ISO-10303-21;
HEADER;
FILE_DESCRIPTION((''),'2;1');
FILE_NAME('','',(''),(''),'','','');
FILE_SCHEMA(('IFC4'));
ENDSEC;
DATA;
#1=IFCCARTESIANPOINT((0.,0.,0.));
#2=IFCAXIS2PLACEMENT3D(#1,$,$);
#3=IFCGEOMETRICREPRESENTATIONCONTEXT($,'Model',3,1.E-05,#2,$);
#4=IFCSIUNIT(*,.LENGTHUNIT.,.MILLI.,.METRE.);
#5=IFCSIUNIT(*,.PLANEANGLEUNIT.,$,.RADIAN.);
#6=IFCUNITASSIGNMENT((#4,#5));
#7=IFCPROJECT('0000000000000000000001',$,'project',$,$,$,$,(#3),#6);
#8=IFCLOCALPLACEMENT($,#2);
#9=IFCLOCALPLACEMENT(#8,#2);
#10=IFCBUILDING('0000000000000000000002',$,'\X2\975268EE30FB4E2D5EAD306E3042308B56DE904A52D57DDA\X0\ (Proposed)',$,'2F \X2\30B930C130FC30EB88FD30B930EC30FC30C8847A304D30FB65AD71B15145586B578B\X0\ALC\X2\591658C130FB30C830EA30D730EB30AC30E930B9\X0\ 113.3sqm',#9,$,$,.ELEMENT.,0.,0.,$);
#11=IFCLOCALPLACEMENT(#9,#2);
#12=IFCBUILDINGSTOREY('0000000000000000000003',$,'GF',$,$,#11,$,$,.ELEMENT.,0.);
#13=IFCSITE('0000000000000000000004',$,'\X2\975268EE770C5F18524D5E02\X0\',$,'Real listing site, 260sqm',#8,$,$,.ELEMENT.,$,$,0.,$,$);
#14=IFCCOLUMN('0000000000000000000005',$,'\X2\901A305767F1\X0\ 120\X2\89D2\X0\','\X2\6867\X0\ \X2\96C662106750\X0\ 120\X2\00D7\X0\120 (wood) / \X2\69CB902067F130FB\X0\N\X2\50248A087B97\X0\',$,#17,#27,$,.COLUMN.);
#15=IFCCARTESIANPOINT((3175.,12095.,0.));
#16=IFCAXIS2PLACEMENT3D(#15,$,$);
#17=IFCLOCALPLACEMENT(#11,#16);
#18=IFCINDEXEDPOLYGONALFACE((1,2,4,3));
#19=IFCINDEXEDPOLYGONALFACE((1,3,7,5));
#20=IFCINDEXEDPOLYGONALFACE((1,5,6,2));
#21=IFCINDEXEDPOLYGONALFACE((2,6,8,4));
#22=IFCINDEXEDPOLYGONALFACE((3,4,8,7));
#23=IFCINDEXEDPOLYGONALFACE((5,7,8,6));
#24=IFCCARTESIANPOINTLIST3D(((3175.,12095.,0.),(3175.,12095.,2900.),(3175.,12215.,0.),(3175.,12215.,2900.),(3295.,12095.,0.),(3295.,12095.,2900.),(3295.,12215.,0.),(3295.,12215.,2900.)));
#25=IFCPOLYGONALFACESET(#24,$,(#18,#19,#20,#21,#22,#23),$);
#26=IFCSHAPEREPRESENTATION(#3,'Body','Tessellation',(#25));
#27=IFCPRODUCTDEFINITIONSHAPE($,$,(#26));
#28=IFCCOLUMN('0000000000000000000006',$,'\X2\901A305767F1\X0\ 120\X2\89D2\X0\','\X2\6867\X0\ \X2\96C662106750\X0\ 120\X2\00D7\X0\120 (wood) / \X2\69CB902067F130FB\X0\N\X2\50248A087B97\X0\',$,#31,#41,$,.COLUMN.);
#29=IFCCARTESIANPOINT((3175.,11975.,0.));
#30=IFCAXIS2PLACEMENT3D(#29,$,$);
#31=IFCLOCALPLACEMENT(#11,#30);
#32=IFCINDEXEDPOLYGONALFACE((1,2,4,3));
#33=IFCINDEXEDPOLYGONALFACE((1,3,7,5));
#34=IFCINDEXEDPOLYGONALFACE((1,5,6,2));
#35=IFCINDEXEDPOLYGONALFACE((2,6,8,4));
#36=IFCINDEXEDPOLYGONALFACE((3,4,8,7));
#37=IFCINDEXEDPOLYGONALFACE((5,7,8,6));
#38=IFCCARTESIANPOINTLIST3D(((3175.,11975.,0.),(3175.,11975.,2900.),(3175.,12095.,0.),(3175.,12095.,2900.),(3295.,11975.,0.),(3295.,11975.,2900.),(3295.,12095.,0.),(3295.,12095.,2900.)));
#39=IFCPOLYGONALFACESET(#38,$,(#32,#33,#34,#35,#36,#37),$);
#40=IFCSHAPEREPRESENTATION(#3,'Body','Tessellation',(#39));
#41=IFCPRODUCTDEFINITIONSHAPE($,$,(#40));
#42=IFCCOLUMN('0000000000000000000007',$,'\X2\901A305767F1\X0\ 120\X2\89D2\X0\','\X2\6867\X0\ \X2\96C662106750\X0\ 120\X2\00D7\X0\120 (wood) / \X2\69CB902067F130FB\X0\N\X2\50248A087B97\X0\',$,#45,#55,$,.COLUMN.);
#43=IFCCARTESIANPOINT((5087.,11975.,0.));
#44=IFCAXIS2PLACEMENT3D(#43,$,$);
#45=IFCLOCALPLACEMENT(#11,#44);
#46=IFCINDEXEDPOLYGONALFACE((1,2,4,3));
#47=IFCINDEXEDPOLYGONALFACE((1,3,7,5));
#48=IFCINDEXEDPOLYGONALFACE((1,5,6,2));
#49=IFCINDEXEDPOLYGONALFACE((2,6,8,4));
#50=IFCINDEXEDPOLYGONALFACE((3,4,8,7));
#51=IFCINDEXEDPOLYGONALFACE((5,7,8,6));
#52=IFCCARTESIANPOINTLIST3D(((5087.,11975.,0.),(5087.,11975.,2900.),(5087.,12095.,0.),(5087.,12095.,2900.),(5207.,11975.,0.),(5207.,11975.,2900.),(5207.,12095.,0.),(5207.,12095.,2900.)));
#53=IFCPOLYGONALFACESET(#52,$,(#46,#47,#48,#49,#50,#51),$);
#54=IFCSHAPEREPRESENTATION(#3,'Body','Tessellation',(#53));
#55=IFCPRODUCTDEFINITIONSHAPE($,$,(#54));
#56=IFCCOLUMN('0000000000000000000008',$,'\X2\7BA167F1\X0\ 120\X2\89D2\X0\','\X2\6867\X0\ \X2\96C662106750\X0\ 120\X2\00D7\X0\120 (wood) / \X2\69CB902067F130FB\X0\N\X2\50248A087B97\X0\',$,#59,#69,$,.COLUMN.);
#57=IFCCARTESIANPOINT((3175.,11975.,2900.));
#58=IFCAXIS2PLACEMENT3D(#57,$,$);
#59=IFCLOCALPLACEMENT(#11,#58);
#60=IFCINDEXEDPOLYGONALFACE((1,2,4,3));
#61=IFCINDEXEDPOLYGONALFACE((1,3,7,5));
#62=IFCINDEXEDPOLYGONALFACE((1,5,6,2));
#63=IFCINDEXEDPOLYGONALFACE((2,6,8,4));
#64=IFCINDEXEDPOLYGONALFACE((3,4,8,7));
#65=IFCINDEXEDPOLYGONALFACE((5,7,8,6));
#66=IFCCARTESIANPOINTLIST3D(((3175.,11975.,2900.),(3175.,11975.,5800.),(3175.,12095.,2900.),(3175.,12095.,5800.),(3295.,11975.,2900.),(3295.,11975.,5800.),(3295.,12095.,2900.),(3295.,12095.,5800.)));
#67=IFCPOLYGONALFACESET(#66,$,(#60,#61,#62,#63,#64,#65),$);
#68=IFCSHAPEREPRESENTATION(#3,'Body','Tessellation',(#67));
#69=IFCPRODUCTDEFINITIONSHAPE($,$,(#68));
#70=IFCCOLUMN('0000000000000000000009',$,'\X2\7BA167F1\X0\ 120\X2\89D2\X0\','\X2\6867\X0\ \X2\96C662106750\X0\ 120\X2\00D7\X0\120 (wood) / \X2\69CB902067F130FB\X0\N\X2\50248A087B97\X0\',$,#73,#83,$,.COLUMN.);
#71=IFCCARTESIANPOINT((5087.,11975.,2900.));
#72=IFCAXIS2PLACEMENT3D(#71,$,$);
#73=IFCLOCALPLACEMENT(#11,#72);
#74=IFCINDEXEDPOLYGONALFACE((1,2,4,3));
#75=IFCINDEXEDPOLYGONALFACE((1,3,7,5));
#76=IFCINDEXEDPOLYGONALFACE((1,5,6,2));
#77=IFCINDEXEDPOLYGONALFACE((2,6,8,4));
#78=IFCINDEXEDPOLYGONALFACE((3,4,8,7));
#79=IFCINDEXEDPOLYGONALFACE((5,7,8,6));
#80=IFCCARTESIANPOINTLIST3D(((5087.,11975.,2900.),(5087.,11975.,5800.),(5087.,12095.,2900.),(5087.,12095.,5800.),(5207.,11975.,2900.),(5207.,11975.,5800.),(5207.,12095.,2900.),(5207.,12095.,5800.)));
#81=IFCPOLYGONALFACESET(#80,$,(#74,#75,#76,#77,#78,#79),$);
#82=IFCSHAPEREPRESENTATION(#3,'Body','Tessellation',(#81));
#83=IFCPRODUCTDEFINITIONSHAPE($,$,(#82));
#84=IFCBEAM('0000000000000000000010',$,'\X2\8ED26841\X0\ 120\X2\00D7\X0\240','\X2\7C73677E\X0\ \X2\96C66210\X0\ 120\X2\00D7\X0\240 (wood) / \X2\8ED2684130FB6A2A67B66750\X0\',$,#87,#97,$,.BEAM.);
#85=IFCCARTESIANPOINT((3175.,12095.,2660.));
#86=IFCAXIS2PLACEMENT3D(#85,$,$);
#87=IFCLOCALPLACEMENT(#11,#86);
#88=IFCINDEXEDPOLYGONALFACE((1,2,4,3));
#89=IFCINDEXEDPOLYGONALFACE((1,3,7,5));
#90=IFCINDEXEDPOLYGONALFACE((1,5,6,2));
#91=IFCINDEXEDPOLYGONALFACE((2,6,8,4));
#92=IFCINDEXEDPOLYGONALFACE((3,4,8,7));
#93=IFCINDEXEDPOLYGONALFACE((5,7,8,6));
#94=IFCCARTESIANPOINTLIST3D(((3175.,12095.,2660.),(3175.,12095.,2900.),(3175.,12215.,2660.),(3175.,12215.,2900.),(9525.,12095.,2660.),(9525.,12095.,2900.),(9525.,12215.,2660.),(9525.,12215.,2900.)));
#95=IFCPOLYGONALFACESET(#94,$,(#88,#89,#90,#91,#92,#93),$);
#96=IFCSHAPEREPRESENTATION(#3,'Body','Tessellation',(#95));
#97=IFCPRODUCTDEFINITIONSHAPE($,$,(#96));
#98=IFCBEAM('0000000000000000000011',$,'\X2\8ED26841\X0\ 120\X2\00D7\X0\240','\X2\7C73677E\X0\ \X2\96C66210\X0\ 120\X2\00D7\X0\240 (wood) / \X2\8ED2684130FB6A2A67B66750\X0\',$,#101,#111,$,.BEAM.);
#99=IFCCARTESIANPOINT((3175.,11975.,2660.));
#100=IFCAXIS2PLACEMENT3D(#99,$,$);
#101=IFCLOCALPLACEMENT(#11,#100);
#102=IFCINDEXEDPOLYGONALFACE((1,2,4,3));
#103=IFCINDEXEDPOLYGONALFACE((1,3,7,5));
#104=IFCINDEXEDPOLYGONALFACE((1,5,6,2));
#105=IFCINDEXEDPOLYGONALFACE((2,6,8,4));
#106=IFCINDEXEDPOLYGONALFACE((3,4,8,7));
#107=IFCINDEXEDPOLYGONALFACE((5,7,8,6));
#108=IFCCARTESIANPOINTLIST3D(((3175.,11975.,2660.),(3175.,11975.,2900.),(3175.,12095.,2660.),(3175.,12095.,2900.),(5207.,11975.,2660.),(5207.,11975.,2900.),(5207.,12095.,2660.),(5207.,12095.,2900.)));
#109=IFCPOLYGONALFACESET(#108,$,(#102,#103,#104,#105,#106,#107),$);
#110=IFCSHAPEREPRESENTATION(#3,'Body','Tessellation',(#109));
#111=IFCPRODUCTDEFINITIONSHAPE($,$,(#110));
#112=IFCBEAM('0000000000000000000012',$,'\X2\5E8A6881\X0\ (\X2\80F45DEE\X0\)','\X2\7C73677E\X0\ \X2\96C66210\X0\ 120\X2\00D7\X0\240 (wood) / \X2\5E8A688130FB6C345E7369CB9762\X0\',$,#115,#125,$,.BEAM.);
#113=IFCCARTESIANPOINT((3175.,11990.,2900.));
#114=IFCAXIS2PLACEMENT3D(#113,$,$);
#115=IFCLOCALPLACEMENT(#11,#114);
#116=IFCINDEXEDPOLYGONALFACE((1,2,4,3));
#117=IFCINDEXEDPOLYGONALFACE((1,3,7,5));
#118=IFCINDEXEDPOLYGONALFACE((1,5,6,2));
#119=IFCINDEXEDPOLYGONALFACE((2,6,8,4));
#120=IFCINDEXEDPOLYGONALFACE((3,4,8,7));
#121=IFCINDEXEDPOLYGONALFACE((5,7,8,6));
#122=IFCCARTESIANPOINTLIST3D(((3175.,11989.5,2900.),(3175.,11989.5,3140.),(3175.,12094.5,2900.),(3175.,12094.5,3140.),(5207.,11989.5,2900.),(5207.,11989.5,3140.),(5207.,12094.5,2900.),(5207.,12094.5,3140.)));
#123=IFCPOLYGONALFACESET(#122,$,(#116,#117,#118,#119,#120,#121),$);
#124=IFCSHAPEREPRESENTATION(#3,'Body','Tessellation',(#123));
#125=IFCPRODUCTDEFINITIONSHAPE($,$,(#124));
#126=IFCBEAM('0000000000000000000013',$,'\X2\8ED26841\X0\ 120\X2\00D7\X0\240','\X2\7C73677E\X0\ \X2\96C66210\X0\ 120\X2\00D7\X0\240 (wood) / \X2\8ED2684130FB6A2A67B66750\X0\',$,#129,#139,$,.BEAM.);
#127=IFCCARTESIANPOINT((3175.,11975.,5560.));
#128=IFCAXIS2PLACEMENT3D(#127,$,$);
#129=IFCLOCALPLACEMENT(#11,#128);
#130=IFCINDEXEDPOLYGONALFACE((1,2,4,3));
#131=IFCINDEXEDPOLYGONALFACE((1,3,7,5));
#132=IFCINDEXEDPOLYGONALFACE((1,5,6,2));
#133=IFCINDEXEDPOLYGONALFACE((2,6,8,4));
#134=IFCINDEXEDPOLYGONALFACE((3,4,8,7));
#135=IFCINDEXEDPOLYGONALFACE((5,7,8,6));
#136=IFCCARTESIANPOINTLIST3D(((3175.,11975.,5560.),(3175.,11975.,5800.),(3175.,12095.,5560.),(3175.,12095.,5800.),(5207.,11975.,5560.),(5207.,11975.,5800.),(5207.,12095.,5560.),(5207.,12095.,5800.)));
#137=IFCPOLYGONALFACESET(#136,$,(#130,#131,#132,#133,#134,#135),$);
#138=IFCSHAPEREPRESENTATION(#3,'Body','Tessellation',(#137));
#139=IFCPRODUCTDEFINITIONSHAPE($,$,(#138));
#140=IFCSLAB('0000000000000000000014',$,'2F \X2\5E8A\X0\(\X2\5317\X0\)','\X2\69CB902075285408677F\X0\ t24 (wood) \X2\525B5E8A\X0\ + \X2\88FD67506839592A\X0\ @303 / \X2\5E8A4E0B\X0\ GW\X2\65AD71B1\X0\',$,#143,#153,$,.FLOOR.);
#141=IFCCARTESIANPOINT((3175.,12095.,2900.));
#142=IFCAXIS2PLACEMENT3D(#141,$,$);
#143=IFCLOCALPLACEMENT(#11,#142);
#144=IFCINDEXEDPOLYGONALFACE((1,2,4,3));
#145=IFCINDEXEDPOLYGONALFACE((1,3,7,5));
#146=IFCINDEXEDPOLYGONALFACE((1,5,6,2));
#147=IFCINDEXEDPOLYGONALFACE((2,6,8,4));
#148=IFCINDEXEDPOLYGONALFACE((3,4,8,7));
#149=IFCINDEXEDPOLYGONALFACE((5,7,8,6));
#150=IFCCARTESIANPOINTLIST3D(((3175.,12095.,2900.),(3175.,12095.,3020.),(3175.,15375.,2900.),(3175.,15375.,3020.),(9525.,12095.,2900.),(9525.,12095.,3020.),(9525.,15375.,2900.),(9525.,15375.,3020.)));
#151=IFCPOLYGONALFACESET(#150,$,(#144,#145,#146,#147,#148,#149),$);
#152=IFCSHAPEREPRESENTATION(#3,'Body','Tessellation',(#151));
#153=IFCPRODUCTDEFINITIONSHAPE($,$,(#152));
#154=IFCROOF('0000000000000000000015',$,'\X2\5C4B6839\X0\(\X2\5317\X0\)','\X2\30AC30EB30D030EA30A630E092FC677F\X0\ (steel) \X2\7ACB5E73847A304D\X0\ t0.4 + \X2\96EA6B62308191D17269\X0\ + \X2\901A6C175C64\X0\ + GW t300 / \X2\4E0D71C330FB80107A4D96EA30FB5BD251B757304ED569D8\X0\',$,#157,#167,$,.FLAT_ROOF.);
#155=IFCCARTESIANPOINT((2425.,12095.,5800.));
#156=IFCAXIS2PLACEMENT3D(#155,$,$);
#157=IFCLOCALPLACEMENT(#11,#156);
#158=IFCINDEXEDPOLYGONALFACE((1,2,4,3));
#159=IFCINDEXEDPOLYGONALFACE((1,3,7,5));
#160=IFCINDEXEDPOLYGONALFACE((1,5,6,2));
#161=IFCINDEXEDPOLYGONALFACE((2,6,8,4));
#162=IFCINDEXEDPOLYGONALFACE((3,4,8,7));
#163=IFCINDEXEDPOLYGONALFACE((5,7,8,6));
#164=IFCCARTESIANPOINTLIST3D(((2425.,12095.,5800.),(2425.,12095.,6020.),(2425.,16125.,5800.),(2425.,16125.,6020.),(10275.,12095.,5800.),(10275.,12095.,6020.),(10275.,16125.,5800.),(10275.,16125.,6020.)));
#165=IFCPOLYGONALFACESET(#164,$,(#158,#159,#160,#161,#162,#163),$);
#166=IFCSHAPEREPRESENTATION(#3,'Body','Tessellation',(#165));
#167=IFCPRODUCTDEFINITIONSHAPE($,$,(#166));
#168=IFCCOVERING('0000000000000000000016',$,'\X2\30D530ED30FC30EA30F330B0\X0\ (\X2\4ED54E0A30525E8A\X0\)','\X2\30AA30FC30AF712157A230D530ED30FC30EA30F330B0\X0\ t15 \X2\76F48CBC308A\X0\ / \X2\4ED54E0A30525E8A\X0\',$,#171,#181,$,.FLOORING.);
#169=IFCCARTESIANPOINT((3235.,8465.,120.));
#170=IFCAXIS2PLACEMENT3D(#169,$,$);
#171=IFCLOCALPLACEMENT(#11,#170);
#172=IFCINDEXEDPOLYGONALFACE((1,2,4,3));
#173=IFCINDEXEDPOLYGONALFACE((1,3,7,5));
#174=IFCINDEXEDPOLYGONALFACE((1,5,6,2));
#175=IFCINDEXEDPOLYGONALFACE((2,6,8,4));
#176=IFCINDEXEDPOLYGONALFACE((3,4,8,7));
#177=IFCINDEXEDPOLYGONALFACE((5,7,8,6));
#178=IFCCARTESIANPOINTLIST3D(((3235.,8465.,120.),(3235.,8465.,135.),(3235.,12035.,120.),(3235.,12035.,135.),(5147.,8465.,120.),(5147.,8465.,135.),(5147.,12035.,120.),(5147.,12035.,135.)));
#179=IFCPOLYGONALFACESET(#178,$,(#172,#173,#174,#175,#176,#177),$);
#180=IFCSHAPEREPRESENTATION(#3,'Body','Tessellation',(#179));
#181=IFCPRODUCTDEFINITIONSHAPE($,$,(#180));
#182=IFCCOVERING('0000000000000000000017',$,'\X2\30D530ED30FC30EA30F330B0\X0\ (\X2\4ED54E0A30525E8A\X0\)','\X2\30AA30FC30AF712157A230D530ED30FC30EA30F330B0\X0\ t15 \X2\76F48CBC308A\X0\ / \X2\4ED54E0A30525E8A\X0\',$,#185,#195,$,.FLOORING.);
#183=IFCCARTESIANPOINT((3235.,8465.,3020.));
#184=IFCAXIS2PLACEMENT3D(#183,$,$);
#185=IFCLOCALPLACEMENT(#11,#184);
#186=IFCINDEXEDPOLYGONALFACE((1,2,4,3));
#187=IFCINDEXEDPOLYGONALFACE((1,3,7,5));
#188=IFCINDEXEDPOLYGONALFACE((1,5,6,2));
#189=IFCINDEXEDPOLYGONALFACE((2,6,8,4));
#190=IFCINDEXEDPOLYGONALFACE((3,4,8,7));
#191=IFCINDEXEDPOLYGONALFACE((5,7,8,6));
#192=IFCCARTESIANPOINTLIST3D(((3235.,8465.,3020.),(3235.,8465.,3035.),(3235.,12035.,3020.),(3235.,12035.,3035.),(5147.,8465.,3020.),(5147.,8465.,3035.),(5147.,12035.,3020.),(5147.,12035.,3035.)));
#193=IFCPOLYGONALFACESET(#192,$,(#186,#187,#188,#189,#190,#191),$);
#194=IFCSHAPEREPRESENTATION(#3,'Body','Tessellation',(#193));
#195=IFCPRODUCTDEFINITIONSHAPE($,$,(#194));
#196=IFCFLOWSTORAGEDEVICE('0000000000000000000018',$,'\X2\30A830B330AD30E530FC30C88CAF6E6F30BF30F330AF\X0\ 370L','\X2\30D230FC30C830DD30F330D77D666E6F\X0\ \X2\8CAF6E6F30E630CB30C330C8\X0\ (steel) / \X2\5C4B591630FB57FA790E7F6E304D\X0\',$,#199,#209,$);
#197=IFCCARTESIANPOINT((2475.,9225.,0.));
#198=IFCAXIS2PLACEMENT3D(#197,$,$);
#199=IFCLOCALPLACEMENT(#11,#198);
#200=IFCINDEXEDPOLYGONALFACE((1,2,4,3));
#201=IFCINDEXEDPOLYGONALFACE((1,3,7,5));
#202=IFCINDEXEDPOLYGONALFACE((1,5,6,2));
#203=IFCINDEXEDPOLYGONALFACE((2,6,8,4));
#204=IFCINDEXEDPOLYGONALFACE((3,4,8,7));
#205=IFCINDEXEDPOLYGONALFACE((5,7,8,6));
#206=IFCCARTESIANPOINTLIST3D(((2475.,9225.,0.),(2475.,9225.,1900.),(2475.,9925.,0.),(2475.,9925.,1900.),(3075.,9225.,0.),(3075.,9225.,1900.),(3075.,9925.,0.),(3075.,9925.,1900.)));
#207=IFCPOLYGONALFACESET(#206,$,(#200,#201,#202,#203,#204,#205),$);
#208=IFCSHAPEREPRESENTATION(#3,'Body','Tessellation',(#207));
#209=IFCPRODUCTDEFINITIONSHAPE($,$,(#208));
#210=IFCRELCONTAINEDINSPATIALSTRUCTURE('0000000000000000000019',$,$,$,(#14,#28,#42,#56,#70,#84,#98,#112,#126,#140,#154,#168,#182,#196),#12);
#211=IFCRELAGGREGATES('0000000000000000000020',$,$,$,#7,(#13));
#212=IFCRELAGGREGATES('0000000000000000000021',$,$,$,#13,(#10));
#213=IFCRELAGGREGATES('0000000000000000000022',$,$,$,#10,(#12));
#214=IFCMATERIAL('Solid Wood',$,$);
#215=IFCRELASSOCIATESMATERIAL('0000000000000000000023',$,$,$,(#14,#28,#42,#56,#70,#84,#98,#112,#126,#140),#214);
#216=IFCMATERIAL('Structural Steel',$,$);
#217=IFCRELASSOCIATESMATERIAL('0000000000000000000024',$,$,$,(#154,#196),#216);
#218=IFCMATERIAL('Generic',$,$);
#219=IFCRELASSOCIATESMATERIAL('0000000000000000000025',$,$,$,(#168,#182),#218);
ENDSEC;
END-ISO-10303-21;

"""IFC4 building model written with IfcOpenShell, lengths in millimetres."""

from ifc_helpers import new_model, si_unit, frame, frame_2d, origin, place, context, project, spatial, rectangle, extrude, material, element, save


model = new_model("IFC4")

# Units and contexts
model_context = context("Model", 3, precision=1e-05, world=origin())
ifc_project = project(units=[si_unit("LENGTHUNIT", "METRE", prefix="MILLI"), si_unit("PLANEANGLEUNIT", "RADIAN")], contexts=[model_context])

# Site, building, storey
site_placement = place(None, origin())
site = spatial("IfcSite", under=ifc_project, at=site_placement, Name="青森県弘前市", ObjectType="Real listing site, 260sqm", CompositionType="ELEMENT", RefElevation=0.0)
building_placement = place(site_placement, origin())
building = spatial("IfcBuilding", under=site, at=building_placement, Name="青森・中庭のある回遊動線 (Proposed)", ObjectType="2F スチール製スレート葺き・断熱充填型ALC外壁・トリプルガラス 113.3sqm", CompositionType="ELEMENT", ElevationOfRefHeight=0.0, ElevationOfTerrain=0.0)
storey_placement = place(building_placement, origin())
storey = spatial("IfcBuildingStorey", under=building, at=storey_placement, Name="GF", CompositionType="ELEMENT", Elevation=0.0)

# Columns
ifc_material_1 = material(Name="Solid Wood")
column_1_placement = place(storey_placement, frame((3175.0, 12095.0, 0.0)))
element("IfcColumn", 1, at=column_1_placement, inside=storey, material=ifc_material_1, Name="通し柱 120角", Description="桧 集成材 120×120 (wood) / 構造柱・N値計算", PredefinedType="COLUMN", context=model_context, shape_type="SweptSolid", body=[
    extrude(rectangle(XDim=120.0, YDim=120.0, at=frame_2d((60.0, 60.0))), frame((3175.0, 12095.0, 0.0)), (0.0, 0.0, 1.0), 2900.0),
])
column_2_placement = place(storey_placement, frame((3175.0, 11975.0, 0.0)))
element("IfcColumn", 2, at=column_2_placement, inside=storey, material=ifc_material_1, Name="通し柱 120角", Description="桧 集成材 120×120 (wood) / 構造柱・N値計算", PredefinedType="COLUMN", context=model_context, shape_type="SweptSolid", body=[
    extrude(rectangle(XDim=120.0, YDim=120.0, at=frame_2d((60.0, 60.0))), frame((3175.0, 11975.0, 0.0)), (0.0, 0.0, 1.0), 2900.0),
])
column_3_placement = place(storey_placement, frame((5087.0, 11975.0, 0.0)))
element("IfcColumn", 3, at=column_3_placement, inside=storey, material=ifc_material_1, Name="通し柱 120角", Description="桧 集成材 120×120 (wood) / 構造柱・N値計算", PredefinedType="COLUMN", context=model_context, shape_type="SweptSolid", body=[
    extrude(rectangle(XDim=120.0, YDim=120.0, at=frame_2d((60.0, 60.0))), frame((5087.0, 11975.0, 0.0)), (0.0, 0.0, 1.0), 2900.0),
])
column_4_placement = place(storey_placement, frame((3175.0, 11975.0, 2900.0)))
element("IfcColumn", 4, at=column_4_placement, inside=storey, material=ifc_material_1, Name="管柱 120角", Description="桧 集成材 120×120 (wood) / 構造柱・N値計算", PredefinedType="COLUMN", context=model_context, shape_type="SweptSolid", body=[
    extrude(rectangle(XDim=120.0, YDim=120.0, at=frame_2d((60.0, 60.0))), frame((3175.0, 11975.0, 2900.0)), (0.0, 0.0, 1.0), 2900.0),
])
column_5_placement = place(storey_placement, frame((5087.0, 11975.0, 2900.0)))
element("IfcColumn", 5, at=column_5_placement, inside=storey, material=ifc_material_1, Name="管柱 120角", Description="桧 集成材 120×120 (wood) / 構造柱・N値計算", PredefinedType="COLUMN", context=model_context, shape_type="SweptSolid", body=[
    extrude(rectangle(XDim=120.0, YDim=120.0, at=frame_2d((60.0, 60.0))), frame((5087.0, 11975.0, 2900.0)), (0.0, 0.0, 1.0), 2900.0),
])

# Beams
beam_1_placement = place(storey_placement, frame((3175.0, 12095.0, 2660.0)))
element("IfcBeam", 6, at=beam_1_placement, inside=storey, material=ifc_material_1, Name="軒桁 120×240", Description="米松 集成 120×240 (wood) / 軒桁・横架材", PredefinedType="BEAM", context=model_context, shape_type="SweptSolid", body=[
    extrude(rectangle(XDim=6350.0, YDim=120.0, at=frame_2d((3175.0, 60.0))), frame((3175.0, 12095.0, 2660.0)), (0.0, 0.0, 1.0), 240.0),
])
beam_2_placement = place(storey_placement, frame((3175.0, 11975.0, 2660.0)))
element("IfcBeam", 7, at=beam_2_placement, inside=storey, material=ifc_material_1, Name="軒桁 120×240", Description="米松 集成 120×240 (wood) / 軒桁・横架材", PredefinedType="BEAM", context=model_context, shape_type="SweptSolid", body=[
    extrude(rectangle(XDim=2032.0, YDim=120.0, at=frame_2d((1016.0, 60.0))), frame((3175.0, 11975.0, 2660.0)), (0.0, 0.0, 1.0), 240.0),
])
beam_3_placement = place(storey_placement, frame((3175.0, 11990.0, 2900.0)))
element("IfcBeam", 8, at=beam_3_placement, inside=storey, material=ifc_material_1, Name="床梁 (胴差)", Description="米松 集成 120×240 (wood) / 床梁・水平構面", PredefinedType="BEAM", context=model_context, shape_type="SweptSolid", body=[
    extrude(rectangle(XDim=2032.0, YDim=105.0, at=frame_2d((1016.0, 52.0))), frame((3175.0, 11990.0, 2900.0)), (0.0, 0.0, 1.0), 240.0),
])
beam_4_placement = place(storey_placement, frame((3175.0, 11975.0, 5560.0)))
element("IfcBeam", 9, at=beam_4_placement, inside=storey, material=ifc_material_1, Name="軒桁 120×240", Description="米松 集成 120×240 (wood) / 軒桁・横架材", PredefinedType="BEAM", context=model_context, shape_type="SweptSolid", body=[
    extrude(rectangle(XDim=2032.0, YDim=120.0, at=frame_2d((1016.0, 60.0))), frame((3175.0, 11975.0, 5560.0)), (0.0, 0.0, 1.0), 240.0),
])

# Slab
slab_1_placement = place(storey_placement, frame((3175.0, 12095.0, 2900.0)))
element("IfcSlab", 10, at=slab_1_placement, inside=storey, material=ifc_material_1, Name="2F 床(北)", Description="構造用合板 t24 (wood) 剛床 + 製材根太 @303 / 床下 GW断熱", PredefinedType="FLOOR", context=model_context, shape_type="SweptSolid", body=[
    extrude(rectangle(XDim=6350.0, YDim=3280.0, at=frame_2d((3175.0, 1640.0))), frame((3175.0, 12095.0, 2900.0)), (0.0, 0.0, 1.0), 120.0),
])

# Roof
ifc_material_2 = material(Name="Structural Steel")
for number, where, name in (
    (11, (2425.0, 12095.0, 5800.0), "屋根(北)"),
):
    element("IfcRoof", number, at=place(storey_placement, frame(where)), inside=storey, material=ifc_material_2, Name=name, Description="ガルバリウム鋼板 (steel) 立平葺き t0.4 + 雪止め金物 + 通気層 + GW t300 / 不燃・耐積雪・寒冷地仕様", PredefinedType="FLAT_ROOF", context=model_context, shape_type="SweptSolid", body=[
        extrude(rectangle(XDim=7850.0, YDim=4030.0, at=frame_2d((3925.0, 2015.0))), frame((2425.0, 12095.0, 5800.0)), (0.0, 0.0, 1.0), 220.0),
    ])

# Coverings
ifc_material_3 = material(Name="Generic")
covering_1_placement = place(storey_placement, frame((3235.0, 8465.0, 120.0)))
element("IfcCovering", 12, at=covering_1_placement, inside=storey, material=ifc_material_3, Name="フローリング (仕上げ床)", Description="オーク無垢フローリング t15 直貼り / 仕上げ床", PredefinedType="FLOORING", context=model_context, shape_type="SweptSolid", body=[
    extrude(rectangle(XDim=1912.0, YDim=3570.0, at=frame_2d((956.0, 1785.0))), frame((3235.0, 8465.0, 120.0)), (0.0, 0.0, 1.0), 15.0),
])
covering_2_placement = place(storey_placement, frame((3235.0, 8465.0, 3020.0)))
element("IfcCovering", 13, at=covering_2_placement, inside=storey, material=ifc_material_3, Name="フローリング (仕上げ床)", Description="オーク無垢フローリング t15 直貼り / 仕上げ床", PredefinedType="FLOORING", context=model_context, shape_type="SweptSolid", body=[
    extrude(rectangle(XDim=1912.0, YDim=3570.0, at=frame_2d((956.0, 1785.0))), frame((3235.0, 8465.0, 3020.0)), (0.0, 0.0, 1.0), 15.0),
])

# Flow storage device
flow_storage_device_placement = place(storey_placement, frame((2475.0, 9225.0, 0.0)))
element("IfcFlowStorageDevice", 14, at=flow_storage_device_placement, inside=storey, material=ifc_material_2, Name="エコキュート貯湯タンク 370L", Description="ヒートポンプ給湯 貯湯ユニット (steel) / 屋外・基礎置き", context=model_context, shape_type="SweptSolid", body=[
    extrude(rectangle(XDim=600.0, YDim=700.0, at=frame_2d((300.0, 350.0))), frame((2475.0, 9225.0, 0.0)), (0.0, 0.0, 1.0), 1900.0),
])

save(model, "model.ifc")
